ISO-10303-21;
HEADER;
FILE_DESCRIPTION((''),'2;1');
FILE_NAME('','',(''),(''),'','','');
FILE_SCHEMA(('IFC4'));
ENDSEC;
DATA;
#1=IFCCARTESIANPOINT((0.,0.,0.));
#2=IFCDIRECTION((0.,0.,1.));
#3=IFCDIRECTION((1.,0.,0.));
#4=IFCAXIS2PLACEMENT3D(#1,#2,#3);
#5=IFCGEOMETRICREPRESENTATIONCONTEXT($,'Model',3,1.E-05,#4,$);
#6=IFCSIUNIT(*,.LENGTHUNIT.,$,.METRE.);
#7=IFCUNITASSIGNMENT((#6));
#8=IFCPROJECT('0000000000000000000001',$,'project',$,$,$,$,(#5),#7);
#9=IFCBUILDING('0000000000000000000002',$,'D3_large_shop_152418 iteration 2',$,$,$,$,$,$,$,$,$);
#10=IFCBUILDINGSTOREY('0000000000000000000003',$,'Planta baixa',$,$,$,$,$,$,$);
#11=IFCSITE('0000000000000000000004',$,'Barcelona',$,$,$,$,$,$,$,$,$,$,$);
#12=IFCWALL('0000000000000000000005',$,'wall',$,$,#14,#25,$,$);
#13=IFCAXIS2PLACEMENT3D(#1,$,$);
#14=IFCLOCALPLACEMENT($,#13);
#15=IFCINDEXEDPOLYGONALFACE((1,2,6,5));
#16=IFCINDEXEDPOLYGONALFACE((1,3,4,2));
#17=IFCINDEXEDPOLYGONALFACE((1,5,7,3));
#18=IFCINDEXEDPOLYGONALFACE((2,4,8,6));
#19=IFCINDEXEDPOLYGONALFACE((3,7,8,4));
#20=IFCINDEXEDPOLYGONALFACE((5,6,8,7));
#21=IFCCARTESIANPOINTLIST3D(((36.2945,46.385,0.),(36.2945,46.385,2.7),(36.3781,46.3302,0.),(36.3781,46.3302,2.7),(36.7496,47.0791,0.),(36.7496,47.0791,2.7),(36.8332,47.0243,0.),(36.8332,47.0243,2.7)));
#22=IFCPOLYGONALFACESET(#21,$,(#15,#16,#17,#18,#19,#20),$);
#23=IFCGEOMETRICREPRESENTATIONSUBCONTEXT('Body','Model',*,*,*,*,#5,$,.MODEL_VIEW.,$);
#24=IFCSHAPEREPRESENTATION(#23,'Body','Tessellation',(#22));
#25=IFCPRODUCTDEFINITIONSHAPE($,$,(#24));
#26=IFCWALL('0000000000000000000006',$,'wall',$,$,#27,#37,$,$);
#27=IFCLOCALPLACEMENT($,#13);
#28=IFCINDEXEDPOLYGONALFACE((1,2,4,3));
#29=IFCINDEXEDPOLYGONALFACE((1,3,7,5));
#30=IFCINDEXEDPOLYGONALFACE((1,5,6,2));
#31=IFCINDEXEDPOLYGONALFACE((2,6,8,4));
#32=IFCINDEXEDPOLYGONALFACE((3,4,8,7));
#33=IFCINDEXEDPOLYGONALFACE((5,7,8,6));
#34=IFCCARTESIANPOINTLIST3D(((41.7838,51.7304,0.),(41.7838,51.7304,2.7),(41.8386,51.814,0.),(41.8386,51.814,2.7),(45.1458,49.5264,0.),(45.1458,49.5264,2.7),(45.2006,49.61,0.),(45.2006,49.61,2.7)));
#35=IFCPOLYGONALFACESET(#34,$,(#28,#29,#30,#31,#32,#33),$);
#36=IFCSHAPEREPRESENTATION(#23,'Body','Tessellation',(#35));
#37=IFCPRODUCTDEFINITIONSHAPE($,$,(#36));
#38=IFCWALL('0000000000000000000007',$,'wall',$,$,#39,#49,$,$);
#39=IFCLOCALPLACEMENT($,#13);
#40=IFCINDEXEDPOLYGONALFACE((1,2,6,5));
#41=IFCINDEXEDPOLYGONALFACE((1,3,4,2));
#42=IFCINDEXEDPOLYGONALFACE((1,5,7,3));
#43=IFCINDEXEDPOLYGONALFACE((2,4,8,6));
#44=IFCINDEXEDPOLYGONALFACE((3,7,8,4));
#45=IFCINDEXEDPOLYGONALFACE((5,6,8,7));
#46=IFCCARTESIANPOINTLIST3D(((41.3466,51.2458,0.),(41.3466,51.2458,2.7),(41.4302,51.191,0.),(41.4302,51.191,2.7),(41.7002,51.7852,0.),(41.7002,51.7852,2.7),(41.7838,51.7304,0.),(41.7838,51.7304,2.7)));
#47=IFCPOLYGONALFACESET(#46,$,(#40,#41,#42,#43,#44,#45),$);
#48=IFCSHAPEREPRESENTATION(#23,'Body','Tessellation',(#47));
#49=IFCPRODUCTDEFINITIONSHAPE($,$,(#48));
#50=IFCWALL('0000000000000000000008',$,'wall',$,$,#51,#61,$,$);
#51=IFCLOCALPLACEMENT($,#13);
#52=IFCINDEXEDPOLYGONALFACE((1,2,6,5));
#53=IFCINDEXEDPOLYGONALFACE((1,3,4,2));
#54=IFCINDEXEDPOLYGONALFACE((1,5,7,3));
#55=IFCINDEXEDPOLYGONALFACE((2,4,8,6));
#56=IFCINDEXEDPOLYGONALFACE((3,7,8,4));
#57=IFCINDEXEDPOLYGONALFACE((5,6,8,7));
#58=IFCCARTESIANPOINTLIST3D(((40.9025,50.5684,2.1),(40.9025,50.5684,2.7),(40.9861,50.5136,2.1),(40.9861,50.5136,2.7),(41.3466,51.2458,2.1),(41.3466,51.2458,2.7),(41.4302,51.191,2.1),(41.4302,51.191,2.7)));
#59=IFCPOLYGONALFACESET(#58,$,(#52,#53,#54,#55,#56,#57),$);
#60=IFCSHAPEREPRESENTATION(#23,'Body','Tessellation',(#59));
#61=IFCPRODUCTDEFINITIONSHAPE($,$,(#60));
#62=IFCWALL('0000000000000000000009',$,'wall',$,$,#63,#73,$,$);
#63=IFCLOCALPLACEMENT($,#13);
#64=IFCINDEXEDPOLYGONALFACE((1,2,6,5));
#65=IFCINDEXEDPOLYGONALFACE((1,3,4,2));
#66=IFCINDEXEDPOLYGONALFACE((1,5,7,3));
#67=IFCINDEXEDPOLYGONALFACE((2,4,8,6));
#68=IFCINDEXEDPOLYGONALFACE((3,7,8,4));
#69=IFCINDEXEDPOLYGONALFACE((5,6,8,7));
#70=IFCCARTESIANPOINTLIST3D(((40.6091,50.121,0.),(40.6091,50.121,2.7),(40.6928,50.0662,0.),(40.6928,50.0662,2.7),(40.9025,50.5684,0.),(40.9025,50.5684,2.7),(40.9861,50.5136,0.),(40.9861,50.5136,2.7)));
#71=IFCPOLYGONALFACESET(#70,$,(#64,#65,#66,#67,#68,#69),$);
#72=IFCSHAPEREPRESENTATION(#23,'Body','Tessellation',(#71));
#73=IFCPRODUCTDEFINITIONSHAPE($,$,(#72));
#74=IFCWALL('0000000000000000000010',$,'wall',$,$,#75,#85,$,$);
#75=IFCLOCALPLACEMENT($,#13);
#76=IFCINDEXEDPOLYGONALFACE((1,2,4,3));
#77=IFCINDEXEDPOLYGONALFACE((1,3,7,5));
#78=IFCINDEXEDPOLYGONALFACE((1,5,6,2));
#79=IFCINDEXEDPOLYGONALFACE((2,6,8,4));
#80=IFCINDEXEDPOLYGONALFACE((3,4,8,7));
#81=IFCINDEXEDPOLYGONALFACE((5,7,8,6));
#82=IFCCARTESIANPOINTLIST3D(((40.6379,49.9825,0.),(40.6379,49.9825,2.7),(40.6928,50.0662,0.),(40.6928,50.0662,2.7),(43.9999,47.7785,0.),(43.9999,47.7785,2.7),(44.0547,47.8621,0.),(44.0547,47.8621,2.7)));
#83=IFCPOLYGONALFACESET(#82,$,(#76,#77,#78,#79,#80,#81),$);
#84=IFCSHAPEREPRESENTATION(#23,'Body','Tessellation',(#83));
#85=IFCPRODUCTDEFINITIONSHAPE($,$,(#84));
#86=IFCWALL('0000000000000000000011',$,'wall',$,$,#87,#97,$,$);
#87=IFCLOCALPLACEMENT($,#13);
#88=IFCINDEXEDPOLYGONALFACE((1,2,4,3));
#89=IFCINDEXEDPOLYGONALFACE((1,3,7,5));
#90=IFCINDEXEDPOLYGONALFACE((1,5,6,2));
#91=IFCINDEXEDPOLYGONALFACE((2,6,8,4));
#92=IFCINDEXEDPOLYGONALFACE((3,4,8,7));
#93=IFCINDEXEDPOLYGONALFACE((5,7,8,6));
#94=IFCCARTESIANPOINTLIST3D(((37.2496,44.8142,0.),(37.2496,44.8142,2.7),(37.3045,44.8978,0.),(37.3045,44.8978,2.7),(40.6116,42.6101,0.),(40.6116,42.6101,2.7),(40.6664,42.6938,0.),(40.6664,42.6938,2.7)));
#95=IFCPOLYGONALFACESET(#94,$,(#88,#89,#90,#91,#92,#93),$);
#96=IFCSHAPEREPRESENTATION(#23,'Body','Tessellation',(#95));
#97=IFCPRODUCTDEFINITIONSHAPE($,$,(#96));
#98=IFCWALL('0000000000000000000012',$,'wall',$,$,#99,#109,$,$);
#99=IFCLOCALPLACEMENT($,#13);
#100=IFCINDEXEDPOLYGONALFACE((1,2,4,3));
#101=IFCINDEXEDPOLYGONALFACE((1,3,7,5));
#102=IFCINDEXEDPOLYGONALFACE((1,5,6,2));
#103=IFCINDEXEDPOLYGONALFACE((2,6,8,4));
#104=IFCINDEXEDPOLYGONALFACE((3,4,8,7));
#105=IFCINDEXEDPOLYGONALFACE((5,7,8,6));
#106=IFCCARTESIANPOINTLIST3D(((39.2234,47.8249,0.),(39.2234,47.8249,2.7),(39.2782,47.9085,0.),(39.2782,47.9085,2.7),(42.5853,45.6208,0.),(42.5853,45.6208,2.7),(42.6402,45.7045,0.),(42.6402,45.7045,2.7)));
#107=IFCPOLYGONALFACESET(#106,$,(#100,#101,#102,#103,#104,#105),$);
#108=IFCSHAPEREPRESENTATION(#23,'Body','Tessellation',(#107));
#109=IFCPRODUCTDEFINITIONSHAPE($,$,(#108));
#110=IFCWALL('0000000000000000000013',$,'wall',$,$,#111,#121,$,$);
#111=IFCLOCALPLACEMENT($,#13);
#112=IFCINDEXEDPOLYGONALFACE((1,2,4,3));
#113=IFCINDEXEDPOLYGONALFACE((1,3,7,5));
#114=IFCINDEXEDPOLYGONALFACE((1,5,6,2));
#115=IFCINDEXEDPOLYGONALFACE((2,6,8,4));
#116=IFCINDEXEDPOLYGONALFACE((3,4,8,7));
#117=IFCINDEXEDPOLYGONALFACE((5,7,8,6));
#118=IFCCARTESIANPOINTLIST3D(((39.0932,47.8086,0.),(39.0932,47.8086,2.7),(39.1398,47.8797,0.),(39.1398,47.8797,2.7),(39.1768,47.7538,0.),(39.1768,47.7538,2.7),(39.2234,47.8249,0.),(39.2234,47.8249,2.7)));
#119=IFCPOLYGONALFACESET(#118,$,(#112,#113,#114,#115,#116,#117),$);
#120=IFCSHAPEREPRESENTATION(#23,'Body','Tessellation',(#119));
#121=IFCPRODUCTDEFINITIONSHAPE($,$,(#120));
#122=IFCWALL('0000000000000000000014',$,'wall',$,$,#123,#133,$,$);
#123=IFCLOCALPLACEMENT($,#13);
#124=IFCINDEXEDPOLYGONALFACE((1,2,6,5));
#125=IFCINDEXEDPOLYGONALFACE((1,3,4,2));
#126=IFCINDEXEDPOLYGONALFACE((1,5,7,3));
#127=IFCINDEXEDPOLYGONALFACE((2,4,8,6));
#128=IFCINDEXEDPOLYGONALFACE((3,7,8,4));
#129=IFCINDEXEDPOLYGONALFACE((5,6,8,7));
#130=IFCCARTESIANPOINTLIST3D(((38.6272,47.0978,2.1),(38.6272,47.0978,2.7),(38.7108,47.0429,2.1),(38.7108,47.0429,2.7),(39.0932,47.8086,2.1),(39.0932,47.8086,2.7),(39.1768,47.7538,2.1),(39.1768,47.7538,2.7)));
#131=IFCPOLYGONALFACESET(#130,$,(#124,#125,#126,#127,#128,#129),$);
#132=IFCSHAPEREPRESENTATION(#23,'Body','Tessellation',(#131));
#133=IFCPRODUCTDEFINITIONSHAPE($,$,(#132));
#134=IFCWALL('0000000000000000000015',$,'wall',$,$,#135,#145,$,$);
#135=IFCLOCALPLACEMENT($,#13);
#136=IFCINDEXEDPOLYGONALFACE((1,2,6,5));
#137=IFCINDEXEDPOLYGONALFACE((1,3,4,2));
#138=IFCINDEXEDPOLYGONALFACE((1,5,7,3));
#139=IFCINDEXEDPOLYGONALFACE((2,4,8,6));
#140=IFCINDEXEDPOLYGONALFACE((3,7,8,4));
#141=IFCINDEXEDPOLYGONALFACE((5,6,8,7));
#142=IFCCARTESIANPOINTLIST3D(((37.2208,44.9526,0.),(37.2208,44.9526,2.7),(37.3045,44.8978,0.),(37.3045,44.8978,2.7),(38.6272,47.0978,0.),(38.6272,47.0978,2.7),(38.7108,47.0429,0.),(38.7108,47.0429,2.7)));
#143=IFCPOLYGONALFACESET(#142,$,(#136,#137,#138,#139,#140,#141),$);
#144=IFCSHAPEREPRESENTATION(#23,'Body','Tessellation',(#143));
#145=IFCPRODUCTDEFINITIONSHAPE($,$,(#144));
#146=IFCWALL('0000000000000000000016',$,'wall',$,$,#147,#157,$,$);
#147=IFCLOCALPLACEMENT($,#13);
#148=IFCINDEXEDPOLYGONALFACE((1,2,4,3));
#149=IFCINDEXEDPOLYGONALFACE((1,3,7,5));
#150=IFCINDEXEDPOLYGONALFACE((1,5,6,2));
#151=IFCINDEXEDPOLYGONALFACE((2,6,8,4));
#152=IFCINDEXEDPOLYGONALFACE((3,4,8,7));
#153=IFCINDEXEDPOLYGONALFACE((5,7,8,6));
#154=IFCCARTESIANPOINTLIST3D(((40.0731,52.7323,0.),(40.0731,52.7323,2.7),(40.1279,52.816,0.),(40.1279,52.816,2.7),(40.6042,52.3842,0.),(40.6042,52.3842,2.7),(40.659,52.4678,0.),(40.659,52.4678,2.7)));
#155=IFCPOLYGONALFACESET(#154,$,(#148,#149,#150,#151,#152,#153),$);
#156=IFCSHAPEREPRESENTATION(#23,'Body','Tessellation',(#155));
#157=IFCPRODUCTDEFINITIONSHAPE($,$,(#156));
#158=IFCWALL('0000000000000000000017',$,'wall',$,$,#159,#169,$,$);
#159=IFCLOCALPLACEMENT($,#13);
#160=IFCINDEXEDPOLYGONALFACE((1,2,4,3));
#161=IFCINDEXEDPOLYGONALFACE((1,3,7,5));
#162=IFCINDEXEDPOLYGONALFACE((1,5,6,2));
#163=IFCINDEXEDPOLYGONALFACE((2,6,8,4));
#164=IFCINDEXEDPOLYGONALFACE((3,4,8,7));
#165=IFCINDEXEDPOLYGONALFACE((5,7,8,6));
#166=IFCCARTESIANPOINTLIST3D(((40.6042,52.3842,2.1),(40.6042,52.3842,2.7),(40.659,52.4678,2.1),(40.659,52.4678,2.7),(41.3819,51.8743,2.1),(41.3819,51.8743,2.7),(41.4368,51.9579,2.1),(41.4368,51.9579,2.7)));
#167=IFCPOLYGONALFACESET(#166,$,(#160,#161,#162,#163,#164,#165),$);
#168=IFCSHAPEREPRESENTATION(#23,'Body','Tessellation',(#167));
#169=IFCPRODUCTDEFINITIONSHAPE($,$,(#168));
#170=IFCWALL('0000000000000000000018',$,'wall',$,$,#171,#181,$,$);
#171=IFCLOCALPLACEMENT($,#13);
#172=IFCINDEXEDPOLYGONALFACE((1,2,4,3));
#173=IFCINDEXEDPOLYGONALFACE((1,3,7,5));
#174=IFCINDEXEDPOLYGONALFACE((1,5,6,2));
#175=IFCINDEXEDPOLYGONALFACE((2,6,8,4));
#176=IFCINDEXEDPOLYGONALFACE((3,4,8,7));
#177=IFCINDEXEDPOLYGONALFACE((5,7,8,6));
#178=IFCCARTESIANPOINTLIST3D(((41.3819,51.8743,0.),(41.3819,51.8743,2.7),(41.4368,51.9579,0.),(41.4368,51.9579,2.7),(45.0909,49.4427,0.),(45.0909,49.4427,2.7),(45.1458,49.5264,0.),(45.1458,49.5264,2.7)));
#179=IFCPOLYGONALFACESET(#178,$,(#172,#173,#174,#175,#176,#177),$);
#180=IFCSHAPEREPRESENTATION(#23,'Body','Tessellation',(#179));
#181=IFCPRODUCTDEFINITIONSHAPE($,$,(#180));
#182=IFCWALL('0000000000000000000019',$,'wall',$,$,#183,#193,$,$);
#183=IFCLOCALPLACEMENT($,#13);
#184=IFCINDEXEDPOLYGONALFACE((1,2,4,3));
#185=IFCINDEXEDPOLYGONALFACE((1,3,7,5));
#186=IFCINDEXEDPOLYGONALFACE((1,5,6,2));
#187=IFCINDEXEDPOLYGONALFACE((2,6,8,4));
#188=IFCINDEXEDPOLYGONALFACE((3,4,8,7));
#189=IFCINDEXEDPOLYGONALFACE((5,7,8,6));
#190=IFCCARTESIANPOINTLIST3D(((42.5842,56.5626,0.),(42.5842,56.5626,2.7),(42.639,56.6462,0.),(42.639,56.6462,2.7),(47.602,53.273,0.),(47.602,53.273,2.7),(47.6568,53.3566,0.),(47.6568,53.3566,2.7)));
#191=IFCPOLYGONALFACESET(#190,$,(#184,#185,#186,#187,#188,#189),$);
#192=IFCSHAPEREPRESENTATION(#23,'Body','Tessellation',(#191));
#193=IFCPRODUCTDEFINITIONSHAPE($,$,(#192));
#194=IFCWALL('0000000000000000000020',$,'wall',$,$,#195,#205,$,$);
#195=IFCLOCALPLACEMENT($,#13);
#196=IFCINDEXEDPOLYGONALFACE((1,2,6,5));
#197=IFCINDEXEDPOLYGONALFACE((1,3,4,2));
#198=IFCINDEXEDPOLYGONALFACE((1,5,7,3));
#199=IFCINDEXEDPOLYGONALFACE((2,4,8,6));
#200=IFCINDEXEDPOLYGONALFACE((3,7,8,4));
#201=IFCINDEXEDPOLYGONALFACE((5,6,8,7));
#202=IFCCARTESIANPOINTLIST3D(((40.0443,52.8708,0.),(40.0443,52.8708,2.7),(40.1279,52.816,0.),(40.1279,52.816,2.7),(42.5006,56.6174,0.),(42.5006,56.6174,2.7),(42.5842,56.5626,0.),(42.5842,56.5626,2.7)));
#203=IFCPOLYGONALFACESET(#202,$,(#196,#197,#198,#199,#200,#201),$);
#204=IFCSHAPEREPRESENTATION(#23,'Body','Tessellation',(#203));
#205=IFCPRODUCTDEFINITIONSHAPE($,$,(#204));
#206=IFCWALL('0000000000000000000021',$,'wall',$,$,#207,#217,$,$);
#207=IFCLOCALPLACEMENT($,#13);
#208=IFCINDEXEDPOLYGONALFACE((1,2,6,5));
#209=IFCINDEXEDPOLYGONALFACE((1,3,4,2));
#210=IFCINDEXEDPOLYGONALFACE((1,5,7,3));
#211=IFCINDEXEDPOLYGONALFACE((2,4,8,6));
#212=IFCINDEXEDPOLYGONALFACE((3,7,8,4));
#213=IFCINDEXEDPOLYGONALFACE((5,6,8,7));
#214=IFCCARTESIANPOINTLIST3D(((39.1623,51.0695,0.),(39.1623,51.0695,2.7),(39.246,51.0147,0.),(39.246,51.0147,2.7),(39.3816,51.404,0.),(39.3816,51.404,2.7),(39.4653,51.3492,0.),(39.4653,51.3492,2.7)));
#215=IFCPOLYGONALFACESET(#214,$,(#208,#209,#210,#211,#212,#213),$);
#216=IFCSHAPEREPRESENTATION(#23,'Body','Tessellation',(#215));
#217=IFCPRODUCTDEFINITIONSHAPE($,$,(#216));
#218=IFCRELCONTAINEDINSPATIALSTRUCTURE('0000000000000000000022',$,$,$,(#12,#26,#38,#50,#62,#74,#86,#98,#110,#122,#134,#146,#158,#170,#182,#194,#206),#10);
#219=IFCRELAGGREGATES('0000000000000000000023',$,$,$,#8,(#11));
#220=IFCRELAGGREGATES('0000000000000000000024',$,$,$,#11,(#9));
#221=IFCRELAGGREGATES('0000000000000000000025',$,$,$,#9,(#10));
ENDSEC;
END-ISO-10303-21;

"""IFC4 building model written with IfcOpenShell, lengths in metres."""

from ifc_helpers import new_model, si_unit, frame, origin, origin_with_axes, place, context, subcontext, project, spatial, polyline, outline, extrude, element, save


model = new_model("IFC4")

# Units and contexts
model_context = context("Model", 3, precision=1e-05, world=origin_with_axes())
body_context = subcontext(model_context, "Body", "Model", "MODEL_VIEW")
ifc_project = project(units=[si_unit("LENGTHUNIT", "METRE")], contexts=[model_context])

# Site, building, storey
site = spatial("IfcSite", under=ifc_project, Name="Barcelona")
building = spatial("IfcBuilding", under=site, Name="D3_large_shop_152418 iteration 2")
storey = spatial("IfcBuildingStorey", under=building, Name="Planta baixa")

# Walls
wall_1_placement = place(None, origin_with_axes())
element("IfcWall", 1, at=wall_1_placement, inside=storey, Name="wall", context=body_context, shape_type="SweptSolid", body=[
    extrude(outline(polyline([(36.8332, 47.0243), (36.3781, 46.3302), (36.2945, 46.385), (36.7496, 47.0791), (36.8332, 47.0243)])), origin(), (0.0, 0.0, 1.0), 2.7),
])
wall_2_placement = place(None, origin_with_axes())
element("IfcWall", 2, at=wall_2_placement, inside=storey, Name="wall", context=body_context, shape_type="SweptSolid", body=[
    extrude(outline(polyline([(45.1458, 49.5264), (41.7838, 51.7304), (41.8386, 51.814), (45.2006, 49.61), (45.1458, 49.5264)])), origin(), (0.0, 0.0, 1.0), 2.7),
])
wall_3_placement = place(None, origin_with_axes())
element("IfcWall", 3, at=wall_3_placement, inside=storey, Name="wall", context=body_context, shape_type="SweptSolid", body=[
    extrude(outline(polyline([(41.7838, 51.7304), (41.4302, 51.191), (41.3466, 51.2458), (41.7002, 51.7852), (41.7838, 51.7304)])), origin(), (0.0, 0.0, 1.0), 2.7),
])
wall_4_placement = place(None, origin_with_axes())
element("IfcWall", 4, at=wall_4_placement, inside=storey, Name="wall", context=body_context, shape_type="SweptSolid", body=[
    extrude(outline(polyline([(41.4302, 51.191), (40.9861, 50.5136), (40.9025, 50.5684), (41.3466, 51.2458), (41.4302, 51.191)])), frame((0.0, 0.0, 2.1)), (0.0, 0.0, 1.0), 0.6),
])
wall_5_placement = place(None, origin_with_axes())
element("IfcWall", 5, at=wall_5_placement, inside=storey, Name="wall", context=body_context, shape_type="SweptSolid", body=[
    extrude(outline(polyline([(40.9861, 50.5136), (40.6928, 50.0662), (40.6091, 50.121), (40.9025, 50.5684), (40.9861, 50.5136)])), origin(), (0.0, 0.0, 1.0), 2.7),
])
wall_6_placement = place(None, origin_with_axes())
element("IfcWall", 6, at=wall_6_placement, inside=storey, Name="wall", context=body_context, shape_type="SweptSolid", body=[
    extrude(outline(polyline([(40.6928, 50.0662), (44.0547, 47.8621), (43.9999, 47.7785), (40.6379, 49.9825), (40.6928, 50.0662)])), origin(), (0.0, 0.0, 1.0), 2.7),
])
wall_7_placement = place(None, origin_with_axes())
element("IfcWall", 7, at=wall_7_placement, inside=storey, Name="wall", context=body_context, shape_type="SweptSolid", body=[
    extrude(outline(polyline([(37.3045, 44.8978), (40.6664, 42.6938), (40.6116, 42.6101), (37.2496, 44.8142), (37.3045, 44.8978)])), origin(), (0.0, 0.0, 1.0), 2.7),
])
wall_8_placement = place(None, origin_with_axes())
element("IfcWall", 8, at=wall_8_placement, inside=storey, Name="wall", context=body_context, shape_type="SweptSolid", body=[
    extrude(outline(polyline([(42.5853, 45.6208), (39.2234, 47.8249), (39.2782, 47.9085), (42.6402, 45.7045), (42.5853, 45.6208)])), origin(), (0.0, 0.0, 1.0), 2.7),
])
wall_9_placement = place(None, origin_with_axes())
element("IfcWall", 9, at=wall_9_placement, inside=storey, Name="wall", context=body_context, shape_type="SweptSolid", body=[
    extrude(outline(polyline([(39.2234, 47.8249), (39.1768, 47.7538), (39.0932, 47.8086), (39.1398, 47.8797), (39.2234, 47.8249)])), origin(), (0.0, 0.0, 1.0), 2.7),
])
wall_10_placement = place(None, origin_with_axes())
element("IfcWall", 10, at=wall_10_placement, inside=storey, Name="wall", context=body_context, shape_type="SweptSolid", body=[
    extrude(outline(polyline([(39.1768, 47.7538), (38.7108, 47.0429), (38.6272, 47.0978), (39.0932, 47.8086), (39.1768, 47.7538)])), frame((0.0, 0.0, 2.1)), (0.0, 0.0, 1.0), 0.6),
])
wall_11_placement = place(None, origin_with_axes())
element("IfcWall", 11, at=wall_11_placement, inside=storey, Name="wall", context=body_context, shape_type="SweptSolid", body=[
    extrude(outline(polyline([(38.7108, 47.0429), (37.3045, 44.8978), (37.2208, 44.9526), (38.6272, 47.0978), (38.7108, 47.0429)])), origin(), (0.0, 0.0, 1.0), 2.7),
])
wall_12_placement = place(None, origin_with_axes())
element("IfcWall", 12, at=wall_12_placement, inside=storey, Name="wall", context=body_context, shape_type="SweptSolid", body=[
    extrude(outline(polyline([(40.1279, 52.816), (40.659, 52.4678), (40.6042, 52.3842), (40.0731, 52.7323), (40.1279, 52.816)])), origin(), (0.0, 0.0, 1.0), 2.7),
])
wall_13_placement = place(None, origin_with_axes())
element("IfcWall", 13, at=wall_13_placement, inside=storey, Name="wall", context=body_context, shape_type="SweptSolid", body=[
    extrude(outline(polyline([(40.659, 52.4678), (41.4368, 51.9579), (41.3819, 51.8743), (40.6042, 52.3842), (40.659, 52.4678)])), frame((0.0, 0.0, 2.1)), (0.0, 0.0, 1.0), 0.6),
])
wall_14_placement = place(None, origin_with_axes())
element("IfcWall", 14, at=wall_14_placement, inside=storey, Name="wall", context=body_context, shape_type="SweptSolid", body=[
    extrude(outline(polyline([(41.4368, 51.9579), (45.1458, 49.5264), (45.0909, 49.4427), (41.3819, 51.8743), (41.4368, 51.9579)])), origin(), (0.0, 0.0, 1.0), 2.7),
])
wall_15_placement = place(None, origin_with_axes())
element("IfcWall", 15, at=wall_15_placement, inside=storey, Name="wall", context=body_context, shape_type="SweptSolid", body=[
    extrude(outline(polyline([(47.602, 53.273), (42.5842, 56.5626), (42.639, 56.6462), (47.6568, 53.3566), (47.602, 53.273)])), origin(), (0.0, 0.0, 1.0), 2.7),
])
wall_16_placement = place(None, origin_with_axes())
element("IfcWall", 16, at=wall_16_placement, inside=storey, Name="wall", context=body_context, shape_type="SweptSolid", body=[
    extrude(outline(polyline([(42.5842, 56.5626), (40.1279, 52.816), (40.0443, 52.8708), (42.5006, 56.6174), (42.5842, 56.5626)])), origin(), (0.0, 0.0, 1.0), 2.7),
])
wall_17_placement = place(None, origin_with_axes())
element("IfcWall", 17, at=wall_17_placement, inside=storey, Name="wall", context=body_context, shape_type="SweptSolid", body=[
    extrude(outline(polyline([(39.4653, 51.3492), (39.246, 51.0147), (39.1623, 51.0695), (39.3816, 51.404), (39.4653, 51.3492)])), origin(), (0.0, 0.0, 1.0), 2.7),
])

save(model, "model.ifc")
